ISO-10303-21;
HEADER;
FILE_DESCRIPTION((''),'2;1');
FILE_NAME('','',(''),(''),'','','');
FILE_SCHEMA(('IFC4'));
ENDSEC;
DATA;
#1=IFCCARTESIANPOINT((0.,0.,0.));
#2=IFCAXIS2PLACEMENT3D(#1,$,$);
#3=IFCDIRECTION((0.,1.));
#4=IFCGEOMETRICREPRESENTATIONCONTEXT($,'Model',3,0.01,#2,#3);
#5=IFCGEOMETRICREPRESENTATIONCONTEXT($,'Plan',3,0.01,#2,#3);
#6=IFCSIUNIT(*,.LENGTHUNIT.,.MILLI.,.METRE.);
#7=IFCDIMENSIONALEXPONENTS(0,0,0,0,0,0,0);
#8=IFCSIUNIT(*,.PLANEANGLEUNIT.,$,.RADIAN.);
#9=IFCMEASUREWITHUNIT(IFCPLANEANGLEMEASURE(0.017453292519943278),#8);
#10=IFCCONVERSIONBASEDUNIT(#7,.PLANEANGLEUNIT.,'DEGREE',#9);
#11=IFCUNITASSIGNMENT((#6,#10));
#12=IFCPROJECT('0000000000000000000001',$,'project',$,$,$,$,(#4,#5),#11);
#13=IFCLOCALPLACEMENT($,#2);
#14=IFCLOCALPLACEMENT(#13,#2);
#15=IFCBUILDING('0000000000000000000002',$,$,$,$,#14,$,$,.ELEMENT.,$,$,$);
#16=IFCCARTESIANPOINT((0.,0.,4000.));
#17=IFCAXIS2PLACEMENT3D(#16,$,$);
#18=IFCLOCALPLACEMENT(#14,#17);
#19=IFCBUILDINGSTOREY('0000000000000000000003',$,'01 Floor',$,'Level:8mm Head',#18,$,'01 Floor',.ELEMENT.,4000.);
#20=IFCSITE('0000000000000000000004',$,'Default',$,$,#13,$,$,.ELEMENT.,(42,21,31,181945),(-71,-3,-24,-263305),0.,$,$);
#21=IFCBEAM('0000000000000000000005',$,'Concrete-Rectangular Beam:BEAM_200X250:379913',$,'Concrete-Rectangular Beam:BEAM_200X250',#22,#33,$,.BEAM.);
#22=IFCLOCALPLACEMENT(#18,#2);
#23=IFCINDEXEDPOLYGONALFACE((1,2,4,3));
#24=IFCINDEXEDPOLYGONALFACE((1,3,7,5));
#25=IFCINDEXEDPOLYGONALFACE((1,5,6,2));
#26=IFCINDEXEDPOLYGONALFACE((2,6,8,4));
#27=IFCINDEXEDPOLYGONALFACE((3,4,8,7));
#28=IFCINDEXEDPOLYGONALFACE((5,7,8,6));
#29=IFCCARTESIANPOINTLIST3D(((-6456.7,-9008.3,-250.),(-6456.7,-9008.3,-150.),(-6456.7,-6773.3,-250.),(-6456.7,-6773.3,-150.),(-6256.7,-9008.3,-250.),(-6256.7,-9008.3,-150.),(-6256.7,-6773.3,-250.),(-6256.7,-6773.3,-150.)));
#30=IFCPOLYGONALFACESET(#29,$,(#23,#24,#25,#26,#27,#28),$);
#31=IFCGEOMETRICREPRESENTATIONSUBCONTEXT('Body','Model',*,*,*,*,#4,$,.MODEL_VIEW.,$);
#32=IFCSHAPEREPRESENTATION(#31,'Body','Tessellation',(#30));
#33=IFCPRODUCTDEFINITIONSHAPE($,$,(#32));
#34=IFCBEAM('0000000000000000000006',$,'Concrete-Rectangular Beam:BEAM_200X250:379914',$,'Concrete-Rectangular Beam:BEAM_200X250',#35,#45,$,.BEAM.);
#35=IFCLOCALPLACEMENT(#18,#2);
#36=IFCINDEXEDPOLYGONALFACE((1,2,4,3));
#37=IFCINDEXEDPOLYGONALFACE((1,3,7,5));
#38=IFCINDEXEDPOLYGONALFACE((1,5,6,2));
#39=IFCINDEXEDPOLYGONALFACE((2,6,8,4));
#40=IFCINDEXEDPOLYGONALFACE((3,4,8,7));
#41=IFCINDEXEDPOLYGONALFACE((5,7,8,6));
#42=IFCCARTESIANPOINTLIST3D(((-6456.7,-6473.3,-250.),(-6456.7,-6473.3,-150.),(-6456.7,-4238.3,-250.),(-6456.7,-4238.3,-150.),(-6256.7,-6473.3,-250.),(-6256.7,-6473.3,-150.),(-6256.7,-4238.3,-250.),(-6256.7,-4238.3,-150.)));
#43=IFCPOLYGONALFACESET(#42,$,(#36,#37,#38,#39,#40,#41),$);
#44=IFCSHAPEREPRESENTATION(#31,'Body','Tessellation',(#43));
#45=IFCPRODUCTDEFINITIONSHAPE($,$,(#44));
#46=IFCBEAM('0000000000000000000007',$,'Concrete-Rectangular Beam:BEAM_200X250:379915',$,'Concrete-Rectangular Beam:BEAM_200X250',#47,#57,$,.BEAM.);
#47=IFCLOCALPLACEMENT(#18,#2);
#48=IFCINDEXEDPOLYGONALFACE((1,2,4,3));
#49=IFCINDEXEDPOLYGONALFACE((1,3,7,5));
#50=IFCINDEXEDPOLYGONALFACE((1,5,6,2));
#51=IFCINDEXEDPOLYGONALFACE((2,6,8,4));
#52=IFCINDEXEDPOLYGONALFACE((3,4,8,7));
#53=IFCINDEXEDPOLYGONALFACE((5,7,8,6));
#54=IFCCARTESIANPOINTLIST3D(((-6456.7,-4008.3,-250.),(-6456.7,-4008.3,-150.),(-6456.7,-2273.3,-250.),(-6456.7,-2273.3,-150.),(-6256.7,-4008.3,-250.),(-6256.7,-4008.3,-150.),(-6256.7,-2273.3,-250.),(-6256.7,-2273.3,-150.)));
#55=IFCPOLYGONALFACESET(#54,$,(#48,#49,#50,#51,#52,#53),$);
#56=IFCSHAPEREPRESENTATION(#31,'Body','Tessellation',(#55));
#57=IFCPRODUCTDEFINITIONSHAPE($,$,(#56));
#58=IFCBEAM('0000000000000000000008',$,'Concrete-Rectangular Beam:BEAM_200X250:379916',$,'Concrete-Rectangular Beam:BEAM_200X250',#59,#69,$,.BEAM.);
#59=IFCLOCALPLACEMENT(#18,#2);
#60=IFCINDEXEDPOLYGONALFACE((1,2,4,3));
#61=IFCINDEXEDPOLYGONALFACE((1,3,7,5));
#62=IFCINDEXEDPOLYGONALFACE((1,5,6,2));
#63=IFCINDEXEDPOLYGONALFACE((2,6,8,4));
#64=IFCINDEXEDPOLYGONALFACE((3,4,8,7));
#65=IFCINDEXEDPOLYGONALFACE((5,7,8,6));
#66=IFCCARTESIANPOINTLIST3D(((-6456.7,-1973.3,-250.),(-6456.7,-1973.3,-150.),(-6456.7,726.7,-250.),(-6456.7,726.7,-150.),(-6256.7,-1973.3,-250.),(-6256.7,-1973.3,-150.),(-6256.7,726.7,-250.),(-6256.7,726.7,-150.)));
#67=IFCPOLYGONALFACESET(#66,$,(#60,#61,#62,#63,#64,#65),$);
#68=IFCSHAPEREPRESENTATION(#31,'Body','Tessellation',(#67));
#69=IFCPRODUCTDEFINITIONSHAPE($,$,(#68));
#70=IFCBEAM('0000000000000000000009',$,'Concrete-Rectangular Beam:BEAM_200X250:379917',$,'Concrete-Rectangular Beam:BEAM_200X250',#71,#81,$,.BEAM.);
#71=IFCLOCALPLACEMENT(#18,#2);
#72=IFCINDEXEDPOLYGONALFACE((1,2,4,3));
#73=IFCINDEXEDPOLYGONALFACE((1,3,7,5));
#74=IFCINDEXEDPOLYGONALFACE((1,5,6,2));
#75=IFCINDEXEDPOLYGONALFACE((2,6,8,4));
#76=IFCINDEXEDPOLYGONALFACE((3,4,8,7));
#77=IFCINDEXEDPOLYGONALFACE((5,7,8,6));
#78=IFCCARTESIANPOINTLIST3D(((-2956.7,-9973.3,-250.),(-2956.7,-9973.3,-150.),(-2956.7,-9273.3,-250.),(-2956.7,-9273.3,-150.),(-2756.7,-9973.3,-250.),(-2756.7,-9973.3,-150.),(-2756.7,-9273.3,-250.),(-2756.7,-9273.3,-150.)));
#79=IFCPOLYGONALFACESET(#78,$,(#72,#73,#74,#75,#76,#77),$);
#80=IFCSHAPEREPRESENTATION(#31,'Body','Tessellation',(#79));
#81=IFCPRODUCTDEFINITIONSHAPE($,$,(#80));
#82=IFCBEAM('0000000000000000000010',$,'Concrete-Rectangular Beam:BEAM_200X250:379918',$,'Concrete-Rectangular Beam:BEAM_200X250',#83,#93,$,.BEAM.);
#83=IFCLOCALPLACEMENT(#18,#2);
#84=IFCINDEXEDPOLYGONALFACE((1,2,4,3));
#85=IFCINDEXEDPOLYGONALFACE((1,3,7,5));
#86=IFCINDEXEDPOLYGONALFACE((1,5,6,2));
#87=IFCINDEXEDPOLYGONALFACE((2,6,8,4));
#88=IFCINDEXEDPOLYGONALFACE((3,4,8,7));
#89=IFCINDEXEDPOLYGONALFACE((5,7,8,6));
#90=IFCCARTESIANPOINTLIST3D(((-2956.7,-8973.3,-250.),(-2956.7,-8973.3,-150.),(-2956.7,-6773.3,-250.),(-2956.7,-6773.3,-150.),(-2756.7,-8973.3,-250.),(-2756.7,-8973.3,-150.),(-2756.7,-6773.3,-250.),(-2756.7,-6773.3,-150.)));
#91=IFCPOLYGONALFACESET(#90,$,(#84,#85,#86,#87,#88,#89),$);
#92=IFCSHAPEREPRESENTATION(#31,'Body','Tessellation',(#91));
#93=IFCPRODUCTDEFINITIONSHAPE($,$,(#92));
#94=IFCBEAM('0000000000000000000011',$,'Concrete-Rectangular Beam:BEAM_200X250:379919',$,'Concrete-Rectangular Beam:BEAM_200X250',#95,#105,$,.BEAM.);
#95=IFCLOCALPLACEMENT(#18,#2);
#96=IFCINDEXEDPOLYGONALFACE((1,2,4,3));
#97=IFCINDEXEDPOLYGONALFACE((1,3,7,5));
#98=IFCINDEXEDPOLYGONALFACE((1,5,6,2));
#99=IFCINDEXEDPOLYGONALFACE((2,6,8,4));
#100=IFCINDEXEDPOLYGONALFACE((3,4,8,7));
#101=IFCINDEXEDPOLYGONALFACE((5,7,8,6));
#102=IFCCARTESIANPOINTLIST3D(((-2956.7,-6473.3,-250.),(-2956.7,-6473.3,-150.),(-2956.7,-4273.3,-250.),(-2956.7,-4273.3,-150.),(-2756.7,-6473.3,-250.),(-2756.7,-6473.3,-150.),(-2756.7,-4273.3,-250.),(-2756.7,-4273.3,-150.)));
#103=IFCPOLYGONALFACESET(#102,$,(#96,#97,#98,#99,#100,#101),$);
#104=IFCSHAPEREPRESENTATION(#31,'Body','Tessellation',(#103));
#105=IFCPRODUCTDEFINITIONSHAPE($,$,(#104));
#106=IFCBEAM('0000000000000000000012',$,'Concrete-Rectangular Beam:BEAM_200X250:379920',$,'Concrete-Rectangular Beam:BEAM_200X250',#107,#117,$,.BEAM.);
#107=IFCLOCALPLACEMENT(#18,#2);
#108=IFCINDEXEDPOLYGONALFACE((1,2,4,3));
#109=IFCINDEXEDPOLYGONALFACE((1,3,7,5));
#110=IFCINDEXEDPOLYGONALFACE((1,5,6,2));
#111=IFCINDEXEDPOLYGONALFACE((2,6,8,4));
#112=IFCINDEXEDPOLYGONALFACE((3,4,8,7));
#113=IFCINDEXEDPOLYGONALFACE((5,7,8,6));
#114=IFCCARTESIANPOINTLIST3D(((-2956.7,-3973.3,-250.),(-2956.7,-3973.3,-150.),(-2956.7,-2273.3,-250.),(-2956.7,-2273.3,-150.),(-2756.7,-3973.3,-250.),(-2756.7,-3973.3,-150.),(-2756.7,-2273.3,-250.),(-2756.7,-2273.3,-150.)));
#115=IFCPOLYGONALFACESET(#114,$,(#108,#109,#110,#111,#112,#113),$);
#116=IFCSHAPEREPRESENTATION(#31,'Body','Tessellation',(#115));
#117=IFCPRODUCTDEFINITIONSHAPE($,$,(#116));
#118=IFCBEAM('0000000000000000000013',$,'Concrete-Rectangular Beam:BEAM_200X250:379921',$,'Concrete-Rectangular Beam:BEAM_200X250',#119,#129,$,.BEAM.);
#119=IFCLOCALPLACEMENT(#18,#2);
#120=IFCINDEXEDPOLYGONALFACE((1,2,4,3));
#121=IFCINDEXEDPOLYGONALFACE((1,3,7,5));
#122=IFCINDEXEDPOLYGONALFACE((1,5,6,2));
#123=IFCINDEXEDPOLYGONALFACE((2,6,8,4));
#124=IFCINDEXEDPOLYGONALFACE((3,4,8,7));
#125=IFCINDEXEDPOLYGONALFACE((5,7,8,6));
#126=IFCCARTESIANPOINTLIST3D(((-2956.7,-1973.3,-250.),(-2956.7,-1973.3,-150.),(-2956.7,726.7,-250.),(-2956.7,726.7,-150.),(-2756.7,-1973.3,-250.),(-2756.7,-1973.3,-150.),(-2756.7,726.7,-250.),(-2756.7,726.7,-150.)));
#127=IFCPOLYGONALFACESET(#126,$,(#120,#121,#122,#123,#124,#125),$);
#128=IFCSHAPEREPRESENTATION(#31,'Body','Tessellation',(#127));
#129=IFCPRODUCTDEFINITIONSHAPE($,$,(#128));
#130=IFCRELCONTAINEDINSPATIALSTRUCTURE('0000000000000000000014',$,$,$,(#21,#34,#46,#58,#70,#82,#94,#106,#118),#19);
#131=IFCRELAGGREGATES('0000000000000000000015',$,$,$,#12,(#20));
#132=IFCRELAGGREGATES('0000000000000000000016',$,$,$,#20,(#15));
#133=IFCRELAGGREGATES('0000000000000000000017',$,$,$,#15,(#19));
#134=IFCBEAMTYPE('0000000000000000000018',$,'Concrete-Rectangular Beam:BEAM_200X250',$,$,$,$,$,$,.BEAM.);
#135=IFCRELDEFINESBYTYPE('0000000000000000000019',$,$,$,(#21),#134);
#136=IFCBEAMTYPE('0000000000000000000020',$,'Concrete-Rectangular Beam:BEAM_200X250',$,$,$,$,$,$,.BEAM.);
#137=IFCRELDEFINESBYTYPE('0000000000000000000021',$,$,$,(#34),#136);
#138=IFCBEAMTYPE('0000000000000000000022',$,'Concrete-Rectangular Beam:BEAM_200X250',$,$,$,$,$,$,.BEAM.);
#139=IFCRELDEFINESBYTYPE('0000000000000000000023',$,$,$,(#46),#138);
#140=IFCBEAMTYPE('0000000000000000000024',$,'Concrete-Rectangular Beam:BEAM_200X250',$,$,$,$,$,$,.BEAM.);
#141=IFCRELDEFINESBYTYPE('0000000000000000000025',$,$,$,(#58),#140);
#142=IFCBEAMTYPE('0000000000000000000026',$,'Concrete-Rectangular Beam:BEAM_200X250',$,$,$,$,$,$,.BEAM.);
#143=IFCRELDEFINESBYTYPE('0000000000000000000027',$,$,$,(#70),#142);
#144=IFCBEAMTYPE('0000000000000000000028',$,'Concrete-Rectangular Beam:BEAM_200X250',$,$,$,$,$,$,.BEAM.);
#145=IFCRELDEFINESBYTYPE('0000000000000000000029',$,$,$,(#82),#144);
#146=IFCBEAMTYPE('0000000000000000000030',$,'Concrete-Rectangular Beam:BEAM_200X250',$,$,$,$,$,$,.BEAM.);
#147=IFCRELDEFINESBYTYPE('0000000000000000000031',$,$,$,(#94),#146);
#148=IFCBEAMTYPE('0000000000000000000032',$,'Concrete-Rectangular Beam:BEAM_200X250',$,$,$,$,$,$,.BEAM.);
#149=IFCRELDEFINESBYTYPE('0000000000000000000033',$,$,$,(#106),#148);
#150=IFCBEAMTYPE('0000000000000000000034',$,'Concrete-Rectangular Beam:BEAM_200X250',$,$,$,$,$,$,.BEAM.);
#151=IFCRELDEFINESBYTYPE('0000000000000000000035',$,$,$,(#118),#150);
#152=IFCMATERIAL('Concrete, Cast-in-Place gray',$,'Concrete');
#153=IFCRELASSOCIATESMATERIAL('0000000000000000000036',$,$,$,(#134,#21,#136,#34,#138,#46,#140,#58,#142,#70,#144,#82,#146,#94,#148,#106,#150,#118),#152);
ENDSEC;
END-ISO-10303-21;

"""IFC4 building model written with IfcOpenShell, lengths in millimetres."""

from ifc_helpers import new_model, entity, si_unit, converted_unit, direction, frame, origin, place, context, subcontext, project, spatial, indexed_curve, outline, extrude, source, transform, mapped, material, type_object, type_shapes, element, save


model = new_model("IFC4")

# Units and contexts
model_context = context("Model", 3, precision=0.01, world=origin(), true_north=direction((0.0, 1.0)))
plan_context = context("Plan", 3, precision=0.01, world=origin(), true_north=direction((0.0, 1.0)))
body_context = subcontext(model_context, "Body", "Model", "MODEL_VIEW")
ifc_project = project(units=[si_unit("LENGTHUNIT", "METRE", prefix="MILLI"), converted_unit("PLANEANGLEUNIT", "DEGREE", entity("IfcPlaneAngleMeasure", 0.017453292519943278), si_unit("PLANEANGLEUNIT", "RADIAN"), dimensions=[0, 0, 0, 0, 0, 0, 0])], contexts=[model_context, plan_context])

# Site, building, storey
site_placement = place(None, origin())
site = spatial("IfcSite", under=ifc_project, at=site_placement, Name="Default", CompositionType="ELEMENT", RefLatitude=(42, 21, 31, 181945), RefLongitude=(-71, -3, -24, -263305), RefElevation=0.0)
building_placement = place(site_placement, origin())
building = spatial("IfcBuilding", under=site, at=building_placement, CompositionType="ELEMENT")
storey_placement = place(building_placement, frame((0.0, 0.0, 4000.0)))
storey = spatial("IfcBuildingStorey", under=building, at=storey_placement, Name="01 Floor", ObjectType="Level:8mm Head", LongName="01 Floor", CompositionType="ELEMENT", Elevation=4000.0)

# Shared definitions
ifc_material = material(Name="Concrete, Cast-in-Place gray", Category="Concrete")

# Beams
beam_type_1 = type_object("IfcBeamType", Name="Concrete-Rectangular Beam:BEAM_200X250", PredefinedType="BEAM", material=ifc_material)
shared_shape_1 = source(origin(), body_context, "Body", "SweptSolid", [
    extrude(outline(indexed_curve([(-100.0, -50.0), (100.0, -50.0), (100.0, 50.0), (-100.0, 50.0), (-100.0, -50.0)], self_intersect=False)), frame((-6356.7, -9008.3, 3800.0), z_axis=(0.0, 1.0, 0.0), x_axis=(-1.0, 0.0, 0.0)), (0.0, 0.0, 1.0), 2235.0),
])
type_shapes(beam_type_1, [shared_shape_1])
beam_1_placement = place(storey_placement, frame((0.0, 0.0, -4000.0)))
element("IfcBeam", 1, at=beam_1_placement, inside=storey, type_object=beam_type_1, material=ifc_material, Name="Concrete-Rectangular Beam:BEAM_200X250:379913", ObjectType="Concrete-Rectangular Beam:BEAM_200X250", PredefinedType="BEAM", context=body_context, shape_type="MappedRepresentation", body=[
    mapped(shared_shape_1, transform((0.0, 0.0, 0.0), scale=1.0)),
])
beam_type_2 = type_object("IfcBeamType", Name="Concrete-Rectangular Beam:BEAM_200X250", PredefinedType="BEAM", material=ifc_material)
shared_shape_2 = source(origin(), body_context, "Body", "SweptSolid", [
    extrude(outline(indexed_curve([(-100.0, -50.0), (100.0, -50.0), (100.0, 50.0), (-100.0, 50.0), (-100.0, -50.0)], self_intersect=False)), frame((-6356.7, -6473.3, 3800.0), z_axis=(0.0, 1.0, 0.0), x_axis=(-1.0, 0.0, 0.0)), (0.0, 0.0, 1.0), 2235.0),
])
type_shapes(beam_type_2, [shared_shape_2])
beam_2_placement = place(storey_placement, frame((0.0, 0.0, -4000.0)))
element("IfcBeam", 2, at=beam_2_placement, inside=storey, type_object=beam_type_2, material=ifc_material, Name="Concrete-Rectangular Beam:BEAM_200X250:379914", ObjectType="Concrete-Rectangular Beam:BEAM_200X250", PredefinedType="BEAM", context=body_context, shape_type="MappedRepresentation", body=[
    mapped(shared_shape_2, transform((0.0, 0.0, 0.0), scale=1.0)),
])
beam_type_3 = type_object("IfcBeamType", Name="Concrete-Rectangular Beam:BEAM_200X250", PredefinedType="BEAM", material=ifc_material)
shared_shape_3 = source(origin(), body_context, "Body", "SweptSolid", [
    extrude(outline(indexed_curve([(-100.0, -50.0), (100.0, -50.0), (100.0, 50.0), (-100.0, 50.0), (-100.0, -50.0)], self_intersect=False)), frame((-6356.7, -4008.3, 3800.0), z_axis=(0.0, 1.0, 0.0), x_axis=(-1.0, 0.0, 0.0)), (0.0, 0.0, 1.0), 1735.0),
])
type_shapes(beam_type_3, [shared_shape_3])
beam_3_placement = place(storey_placement, frame((0.0, 0.0, -4000.0)))
element("IfcBeam", 3, at=beam_3_placement, inside=storey, type_object=beam_type_3, material=ifc_material, Name="Concrete-Rectangular Beam:BEAM_200X250:379915", ObjectType="Concrete-Rectangular Beam:BEAM_200X250", PredefinedType="BEAM", context=body_context, shape_type="MappedRepresentation", body=[
    mapped(shared_shape_3, transform((0.0, 0.0, 0.0), scale=1.0)),
])
beam_type_4 = type_object("IfcBeamType", Name="Concrete-Rectangular Beam:BEAM_200X250", PredefinedType="BEAM", material=ifc_material)
shared_shape_4 = source(origin(), body_context, "Body", "SweptSolid", [
    extrude(outline(indexed_curve([(-100.0, -50.0), (100.0, -50.0), (100.0, 50.0), (-100.0, 50.0), (-100.0, -50.0)], self_intersect=False)), frame((-6356.7, -1973.3, 3800.0), z_axis=(0.0, 1.0, 0.0), x_axis=(-1.0, 0.0, 0.0)), (0.0, 0.0, 1.0), 2700.0),
])
type_shapes(beam_type_4, [shared_shape_4])
beam_4_placement = place(storey_placement, frame((0.0, 0.0, -4000.0)))
element("IfcBeam", 4, at=beam_4_placement, inside=storey, type_object=beam_type_4, material=ifc_material, Name="Concrete-Rectangular Beam:BEAM_200X250:379916", ObjectType="Concrete-Rectangular Beam:BEAM_200X250", PredefinedType="BEAM", context=body_context, shape_type="MappedRepresentation", body=[
    mapped(shared_shape_4, transform((0.0, 0.0, 0.0), scale=1.0)),
])
beam_type_5 = type_object("IfcBeamType", Name="Concrete-Rectangular Beam:BEAM_200X250", PredefinedType="BEAM", material=ifc_material)
shared_shape_5 = source(origin(), body_context, "Body", "SweptSolid", [
    extrude(outline(indexed_curve([(-100.0, -50.0), (100.0, -50.0), (100.0, 50.0), (-100.0, 50.0), (-100.0, -50.0)], self_intersect=False)), frame((-2856.7, -9973.3, 3800.0), z_axis=(0.0, 1.0, 0.0), x_axis=(-1.0, 0.0, 0.0)), (0.0, 0.0, 1.0), 700.0),
])
type_shapes(beam_type_5, [shared_shape_5])
beam_5_placement = place(storey_placement, frame((0.0, 0.0, -4000.0)))
element("IfcBeam", 5, at=beam_5_placement, inside=storey, type_object=beam_type_5, material=ifc_material, Name="Concrete-Rectangular Beam:BEAM_200X250:379917", ObjectType="Concrete-Rectangular Beam:BEAM_200X250", PredefinedType="BEAM", context=body_context, shape_type="MappedRepresentation", body=[
    mapped(shared_shape_5, transform((0.0, 0.0, 0.0), scale=1.0)),
])
beam_type_6 = type_object("IfcBeamType", Name="Concrete-Rectangular Beam:BEAM_200X250", PredefinedType="BEAM", material=ifc_material)
shared_shape_6 = source(origin(), body_context, "Body", "SweptSolid", [
    extrude(outline(indexed_curve([(-100.0, -50.0), (100.0, -50.0), (100.0, 50.0), (-100.0, 50.0), (-100.0, -50.0)], self_intersect=False)), frame((-2856.7, -8973.3, 3800.0), z_axis=(0.0, 1.0, 0.0), x_axis=(-1.0, 0.0, 0.0)), (0.0, 0.0, 1.0), 2200.0),
])
type_shapes(beam_type_6, [shared_shape_6])
beam_6_placement = place(storey_placement, frame((0.0, 0.0, -4000.0)))
element("IfcBeam", 6, at=beam_6_placement, inside=storey, type_object=beam_type_6, material=ifc_material, Name="Concrete-Rectangular Beam:BEAM_200X250:379918", ObjectType="Concrete-Rectangular Beam:BEAM_200X250", PredefinedType="BEAM", context=body_context, shape_type="MappedRepresentation", body=[
    mapped(shared_shape_6, transform((0.0, 0.0, 0.0), scale=1.0)),
])
beam_type_7 = type_object("IfcBeamType", Name="Concrete-Rectangular Beam:BEAM_200X250", PredefinedType="BEAM", material=ifc_material)
shared_shape_7 = source(origin(), body_context, "Body", "SweptSolid", [
    extrude(outline(indexed_curve([(-100.0, -50.0), (100.0, -50.0), (100.0, 50.0), (-100.0, 50.0), (-100.0, -50.0)], self_intersect=False)), frame((-2856.7, -6473.3, 3800.0), z_axis=(0.0, 1.0, 0.0), x_axis=(-1.0, 0.0, 0.0)), (0.0, 0.0, 1.0), 2200.0),
])
type_shapes(beam_type_7, [shared_shape_7])
beam_7_placement = place(storey_placement, frame((0.0, 0.0, -4000.0)))
element("IfcBeam", 7, at=beam_7_placement, inside=storey, type_object=beam_type_7, material=ifc_material, Name="Concrete-Rectangular Beam:BEAM_200X250:379919", ObjectType="Concrete-Rectangular Beam:BEAM_200X250", PredefinedType="BEAM", context=body_context, shape_type="MappedRepresentation", body=[
    mapped(shared_shape_7, transform((0.0, 0.0, 0.0), scale=1.0)),
])
beam_type_8 = type_object("IfcBeamType", Name="Concrete-Rectangular Beam:BEAM_200X250", PredefinedType="BEAM", material=ifc_material)
shared_shape_8 = source(origin(), body_context, "Body", "SweptSolid", [
    extrude(outline(indexed_curve([(-100.0, -50.0), (100.0, -50.0), (100.0, 50.0), (-100.0, 50.0), (-100.0, -50.0)], self_intersect=False)), frame((-2856.7, -3973.3, 3800.0), z_axis=(0.0, 1.0, 0.0), x_axis=(-1.0, 0.0, 0.0)), (0.0, 0.0, 1.0), 1700.0),
])
type_shapes(beam_type_8, [shared_shape_8])
beam_8_placement = place(storey_placement, frame((0.0, 0.0, -4000.0)))
element("IfcBeam", 8, at=beam_8_placement, inside=storey, type_object=beam_type_8, material=ifc_material, Name="Concrete-Rectangular Beam:BEAM_200X250:379920", ObjectType="Concrete-Rectangular Beam:BEAM_200X250", PredefinedType="BEAM", context=body_context, shape_type="MappedRepresentation", body=[
    mapped(shared_shape_8, transform((0.0, 0.0, 0.0), scale=1.0)),
])
beam_type_9 = type_object("IfcBeamType", Name="Concrete-Rectangular Beam:BEAM_200X250", PredefinedType="BEAM", material=ifc_material)
shared_shape_9 = source(origin(), body_context, "Body", "SweptSolid", [
    extrude(outline(indexed_curve([(-100.0, -50.0), (100.0, -50.0), (100.0, 50.0), (-100.0, 50.0), (-100.0, -50.0)], self_intersect=False)), frame((-2856.7, -1973.3, 3800.0), z_axis=(0.0, 1.0, 0.0), x_axis=(-1.0, 0.0, 0.0)), (0.0, 0.0, 1.0), 2700.0),
])
type_shapes(beam_type_9, [shared_shape_9])
beam_9_placement = place(storey_placement, frame((0.0, 0.0, -4000.0)))
element("IfcBeam", 9, at=beam_9_placement, inside=storey, type_object=beam_type_9, material=ifc_material, Name="Concrete-Rectangular Beam:BEAM_200X250:379921", ObjectType="Concrete-Rectangular Beam:BEAM_200X250", PredefinedType="BEAM", context=body_context, shape_type="MappedRepresentation", body=[
    mapped(shared_shape_9, transform((0.0, 0.0, 0.0), scale=1.0)),
])

save(model, "model.ifc")
